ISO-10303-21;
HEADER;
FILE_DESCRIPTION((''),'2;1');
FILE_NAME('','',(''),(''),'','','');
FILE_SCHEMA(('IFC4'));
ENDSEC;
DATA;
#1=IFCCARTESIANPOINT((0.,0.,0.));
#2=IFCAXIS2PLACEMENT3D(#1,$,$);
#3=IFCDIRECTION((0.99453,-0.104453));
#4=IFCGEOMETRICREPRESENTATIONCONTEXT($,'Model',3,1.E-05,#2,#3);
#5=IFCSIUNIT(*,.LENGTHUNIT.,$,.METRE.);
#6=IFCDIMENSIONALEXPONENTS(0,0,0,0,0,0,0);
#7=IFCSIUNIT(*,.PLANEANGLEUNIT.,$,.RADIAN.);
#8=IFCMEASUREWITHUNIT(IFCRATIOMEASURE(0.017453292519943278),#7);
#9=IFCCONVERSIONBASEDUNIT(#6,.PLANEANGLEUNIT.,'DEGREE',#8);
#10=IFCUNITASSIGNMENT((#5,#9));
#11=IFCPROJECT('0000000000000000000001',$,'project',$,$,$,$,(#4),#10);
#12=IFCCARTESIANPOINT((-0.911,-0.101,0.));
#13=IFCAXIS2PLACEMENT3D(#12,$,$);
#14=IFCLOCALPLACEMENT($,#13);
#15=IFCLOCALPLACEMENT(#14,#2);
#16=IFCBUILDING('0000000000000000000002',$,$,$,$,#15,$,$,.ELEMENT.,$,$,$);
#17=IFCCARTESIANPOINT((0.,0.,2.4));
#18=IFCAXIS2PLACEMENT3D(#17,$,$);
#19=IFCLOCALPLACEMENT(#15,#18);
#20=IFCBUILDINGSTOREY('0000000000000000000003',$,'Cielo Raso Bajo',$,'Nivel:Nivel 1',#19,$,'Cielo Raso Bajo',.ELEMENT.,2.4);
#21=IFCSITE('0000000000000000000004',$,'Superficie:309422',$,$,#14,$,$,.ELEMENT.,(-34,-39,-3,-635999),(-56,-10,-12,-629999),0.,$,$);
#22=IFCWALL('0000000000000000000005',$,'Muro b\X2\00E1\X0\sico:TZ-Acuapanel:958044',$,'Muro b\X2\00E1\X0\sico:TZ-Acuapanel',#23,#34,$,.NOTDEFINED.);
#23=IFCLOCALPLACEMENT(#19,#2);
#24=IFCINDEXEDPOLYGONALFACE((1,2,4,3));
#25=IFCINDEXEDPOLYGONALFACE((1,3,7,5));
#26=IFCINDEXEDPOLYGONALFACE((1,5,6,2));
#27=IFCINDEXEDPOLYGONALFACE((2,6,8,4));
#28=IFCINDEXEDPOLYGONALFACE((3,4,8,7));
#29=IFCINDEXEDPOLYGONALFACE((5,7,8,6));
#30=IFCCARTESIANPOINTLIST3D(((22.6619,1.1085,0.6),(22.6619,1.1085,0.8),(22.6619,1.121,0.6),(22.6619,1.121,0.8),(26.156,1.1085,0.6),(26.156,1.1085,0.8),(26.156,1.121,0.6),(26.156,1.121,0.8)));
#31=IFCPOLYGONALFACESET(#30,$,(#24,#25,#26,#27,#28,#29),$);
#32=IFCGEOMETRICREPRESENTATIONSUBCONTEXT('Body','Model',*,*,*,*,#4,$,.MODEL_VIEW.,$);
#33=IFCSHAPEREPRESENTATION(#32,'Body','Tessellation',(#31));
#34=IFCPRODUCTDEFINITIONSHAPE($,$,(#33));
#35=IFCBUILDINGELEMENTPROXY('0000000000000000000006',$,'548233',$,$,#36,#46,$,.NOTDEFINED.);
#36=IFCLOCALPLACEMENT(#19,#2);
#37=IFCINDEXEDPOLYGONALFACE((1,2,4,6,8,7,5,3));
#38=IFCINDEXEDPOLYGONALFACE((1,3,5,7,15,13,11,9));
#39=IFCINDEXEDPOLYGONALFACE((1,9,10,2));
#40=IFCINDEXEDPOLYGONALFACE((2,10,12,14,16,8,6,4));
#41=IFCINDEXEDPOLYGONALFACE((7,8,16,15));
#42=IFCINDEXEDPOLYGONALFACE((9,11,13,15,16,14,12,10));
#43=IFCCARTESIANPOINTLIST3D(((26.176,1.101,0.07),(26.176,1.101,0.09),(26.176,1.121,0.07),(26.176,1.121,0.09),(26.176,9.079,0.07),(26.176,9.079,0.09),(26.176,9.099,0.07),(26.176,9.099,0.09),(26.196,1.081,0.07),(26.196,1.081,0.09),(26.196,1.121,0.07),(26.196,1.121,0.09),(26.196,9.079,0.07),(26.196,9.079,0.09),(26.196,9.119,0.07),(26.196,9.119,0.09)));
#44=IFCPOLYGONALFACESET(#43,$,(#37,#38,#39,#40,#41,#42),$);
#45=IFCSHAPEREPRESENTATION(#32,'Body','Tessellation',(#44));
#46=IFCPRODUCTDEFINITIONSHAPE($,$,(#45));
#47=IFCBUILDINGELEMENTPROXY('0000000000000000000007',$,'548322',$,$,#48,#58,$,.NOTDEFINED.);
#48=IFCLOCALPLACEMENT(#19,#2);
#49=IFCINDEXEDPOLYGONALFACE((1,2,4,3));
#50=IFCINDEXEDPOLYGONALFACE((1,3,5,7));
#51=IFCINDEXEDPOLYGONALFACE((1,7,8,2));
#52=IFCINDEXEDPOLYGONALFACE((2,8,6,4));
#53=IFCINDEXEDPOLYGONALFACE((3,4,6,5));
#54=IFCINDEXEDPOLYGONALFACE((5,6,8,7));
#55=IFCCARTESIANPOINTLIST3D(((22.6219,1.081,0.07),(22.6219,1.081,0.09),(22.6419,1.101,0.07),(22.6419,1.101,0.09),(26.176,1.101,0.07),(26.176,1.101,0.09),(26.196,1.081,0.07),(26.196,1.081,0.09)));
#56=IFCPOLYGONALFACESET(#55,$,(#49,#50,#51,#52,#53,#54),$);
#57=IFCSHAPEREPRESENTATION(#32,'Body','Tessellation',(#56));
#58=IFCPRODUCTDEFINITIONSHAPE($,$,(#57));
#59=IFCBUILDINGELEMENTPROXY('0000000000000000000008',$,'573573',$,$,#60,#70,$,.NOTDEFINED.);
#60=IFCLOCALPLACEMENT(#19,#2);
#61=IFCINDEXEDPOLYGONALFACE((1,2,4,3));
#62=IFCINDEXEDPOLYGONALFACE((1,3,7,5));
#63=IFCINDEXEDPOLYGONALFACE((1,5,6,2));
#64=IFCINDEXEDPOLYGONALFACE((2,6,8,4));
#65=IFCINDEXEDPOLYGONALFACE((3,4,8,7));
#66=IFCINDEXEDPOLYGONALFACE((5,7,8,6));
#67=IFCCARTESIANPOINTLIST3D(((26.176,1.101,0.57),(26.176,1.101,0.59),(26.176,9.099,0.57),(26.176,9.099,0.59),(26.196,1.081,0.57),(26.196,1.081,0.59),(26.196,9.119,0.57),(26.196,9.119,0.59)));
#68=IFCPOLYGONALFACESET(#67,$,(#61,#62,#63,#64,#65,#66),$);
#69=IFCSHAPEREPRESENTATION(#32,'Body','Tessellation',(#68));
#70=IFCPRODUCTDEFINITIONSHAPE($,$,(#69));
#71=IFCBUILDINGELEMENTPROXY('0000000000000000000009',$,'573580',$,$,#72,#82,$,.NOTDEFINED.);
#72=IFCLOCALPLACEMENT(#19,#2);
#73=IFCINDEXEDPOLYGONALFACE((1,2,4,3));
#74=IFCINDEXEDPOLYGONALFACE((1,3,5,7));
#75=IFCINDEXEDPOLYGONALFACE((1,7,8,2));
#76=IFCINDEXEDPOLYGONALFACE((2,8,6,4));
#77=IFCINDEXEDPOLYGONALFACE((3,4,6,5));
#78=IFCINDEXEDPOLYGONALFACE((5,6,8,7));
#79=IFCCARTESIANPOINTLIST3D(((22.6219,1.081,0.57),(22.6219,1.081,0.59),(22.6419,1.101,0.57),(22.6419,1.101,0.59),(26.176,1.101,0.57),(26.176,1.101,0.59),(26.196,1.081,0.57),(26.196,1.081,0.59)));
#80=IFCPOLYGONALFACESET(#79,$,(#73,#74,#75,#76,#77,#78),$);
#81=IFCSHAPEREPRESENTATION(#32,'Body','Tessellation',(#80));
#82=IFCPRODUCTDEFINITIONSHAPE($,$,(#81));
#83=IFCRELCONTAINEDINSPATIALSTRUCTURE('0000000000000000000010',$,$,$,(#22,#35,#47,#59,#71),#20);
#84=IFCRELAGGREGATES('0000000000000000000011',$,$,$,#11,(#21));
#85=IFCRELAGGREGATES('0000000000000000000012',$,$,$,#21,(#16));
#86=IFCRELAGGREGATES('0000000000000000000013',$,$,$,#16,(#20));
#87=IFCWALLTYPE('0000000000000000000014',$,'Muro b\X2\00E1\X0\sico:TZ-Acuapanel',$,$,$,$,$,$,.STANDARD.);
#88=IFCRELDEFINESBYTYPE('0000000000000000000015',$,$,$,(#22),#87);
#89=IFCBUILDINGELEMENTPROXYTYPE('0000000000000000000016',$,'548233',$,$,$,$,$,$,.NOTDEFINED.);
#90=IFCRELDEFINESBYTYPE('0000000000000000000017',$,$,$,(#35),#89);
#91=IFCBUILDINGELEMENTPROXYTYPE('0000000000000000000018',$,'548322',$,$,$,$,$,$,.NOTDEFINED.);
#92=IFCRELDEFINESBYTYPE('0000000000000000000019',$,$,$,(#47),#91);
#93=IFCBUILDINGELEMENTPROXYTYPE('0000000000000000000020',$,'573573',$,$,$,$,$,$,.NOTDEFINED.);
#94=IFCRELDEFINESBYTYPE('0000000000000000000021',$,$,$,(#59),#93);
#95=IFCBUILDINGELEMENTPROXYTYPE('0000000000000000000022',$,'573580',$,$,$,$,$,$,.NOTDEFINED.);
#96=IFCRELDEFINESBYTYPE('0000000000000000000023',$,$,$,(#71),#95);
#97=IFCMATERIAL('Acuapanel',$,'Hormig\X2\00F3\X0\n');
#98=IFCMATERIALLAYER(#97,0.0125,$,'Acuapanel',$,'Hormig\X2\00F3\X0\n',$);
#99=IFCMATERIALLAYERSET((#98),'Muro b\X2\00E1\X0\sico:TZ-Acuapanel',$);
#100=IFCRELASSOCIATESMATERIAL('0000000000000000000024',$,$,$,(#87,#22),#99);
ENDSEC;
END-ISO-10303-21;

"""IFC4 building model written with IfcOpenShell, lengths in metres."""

from ifc_helpers import new_model, entity, si_unit, converted_unit, direction, frame, frame_2d, origin, place, context, subcontext, project, spatial, polyline, rectangle, outline, extrude, clip, bounded_halfspace, material, layer, layer_set, layer_usage, type_object, element, save


model = new_model("IFC4")

# Units and contexts
model_context = context("Model", 3, precision=1e-05, world=origin(), true_north=direction((0.99453, -0.104453)))
body_context = subcontext(model_context, "Body", "Model", "MODEL_VIEW")
ifc_project = project(units=[si_unit("LENGTHUNIT", "METRE"), converted_unit("PLANEANGLEUNIT", "DEGREE", entity("IfcRatioMeasure", 0.017453292519943278), si_unit("PLANEANGLEUNIT", "RADIAN"), dimensions=[0, 0, 0, 0, 0, 0, 0])], contexts=[model_context])

# Site, building, storey
site_placement = place(None, frame((-0.911, -0.101, 0.0)))
site = spatial("IfcSite", under=ifc_project, at=site_placement, Name="Superficie:309422", CompositionType="ELEMENT", RefLatitude=(-34, -39, -3, -635999), RefLongitude=(-56, -10, -12, -629999), RefElevation=0.0)
building_placement = place(site_placement, origin())
building = spatial("IfcBuilding", under=site, at=building_placement, CompositionType="ELEMENT")
storey_placement = place(building_placement, frame((0.0, 0.0, 2.4)))
storey = spatial("IfcBuildingStorey", under=building, at=storey_placement, Name="Cielo Raso Bajo", ObjectType="Nivel:Nivel 1", LongName="Cielo Raso Bajo", CompositionType="ELEMENT", Elevation=2.4)

# Shared definitions
ifc_material_1 = material(Name="Acuapanel", Category="Hormigón")

# Wall
ifc_layer_1 = layer(ifc_material_1, 0.0125, Name="Acuapanel", Category="Hormigón")
ifc_layer_set_1 = layer_set([ifc_layer_1], Name="Muro básico:TZ-Acuapanel")
wall_type_1 = type_object("IfcWallType", Name="Muro básico:TZ-Acuapanel", PredefinedType="STANDARD", material=ifc_layer_set_1)
ifc_layer_usage_1 = layer_usage(ifc_layer_set_1, "AXIS2", "POSITIVE", -0.0063)
wall_1_placement = place(storey_placement, frame((22.6619, 1.1148, 0.6)))
element("IfcWall", 1, at=wall_1_placement, inside=storey, type_object=wall_type_1, material=ifc_layer_usage_1, Name="Muro básico:TZ-Acuapanel:958044", ObjectType="Muro básico:TZ-Acuapanel", PredefinedType="NOTDEFINED", context=body_context, shape_type="Clipping", body=[
    clip(extrude(rectangle(XDim=3.494, YDim=0.0125, at=frame_2d((1.747, 0.0), x_axis=(-1.0, 0.0))), origin(), (0.0, 0.0, 1.0), 0.2), bounded_halfspace(frame((0.0, -0.0062, 0.2)), False, frame((0.0, -0.0062, 0.2)), polyline([(0.0, 0.0), (1.065, 0.0), (1.065, 0.0038), (0.0, 0.0038), (0.0, 0.0)]))),
])

# Building element proxies
building_element_proxy_type_1 = type_object("IfcBuildingElementProxyType", Name="548233", PredefinedType="NOTDEFINED")
proxy_1_placement = place(storey_placement, frame((26.176, 1.081, 0.07)))
element("IfcBuildingElementProxy", 2, at=proxy_1_placement, inside=storey, type_object=building_element_proxy_type_1, Name="548233", PredefinedType="NOTDEFINED", context=body_context, shape_type="SweptSolid", body=[
    extrude(outline(polyline([(-3.999, -0.01), (-3.979, -0.01), (3.979, -0.01), (3.999, -0.01), (4.019, 0.01), (3.979, 0.01), (-3.979, 0.01), (-4.019, 0.01), (-3.999, -0.01)])), frame((0.01, 4.019, 0.0), z_axis=(0.0, 0.0, 1.0), x_axis=(0.0, -1.0, 0.0)), (0.0, 0.0, 1.0), 0.02),
])
building_element_proxy_type_2 = type_object("IfcBuildingElementProxyType", Name="548322", PredefinedType="NOTDEFINED")
proxy_2_placement = place(storey_placement, frame((22.6219, 1.081, 0.07)))
element("IfcBuildingElementProxy", 3, at=proxy_2_placement, inside=storey, type_object=building_element_proxy_type_2, Name="548322", PredefinedType="NOTDEFINED", context=body_context, shape_type="SweptSolid", body=[
    extrude(outline(polyline([(-1.767, -0.01), (1.767, -0.01), (1.787, 0.01), (-1.787, 0.01), (-1.767, -0.01)])), frame((1.787, 0.01, 0.0), z_axis=(0.0, 0.0, 1.0), x_axis=(-1.0, 0.0, 0.0)), (0.0, 0.0, 1.0), 0.02),
])
building_element_proxy_type_3 = type_object("IfcBuildingElementProxyType", Name="573573", PredefinedType="NOTDEFINED")
proxy_3_placement = place(storey_placement, frame((26.176, 1.081, 0.57)))
element("IfcBuildingElementProxy", 4, at=proxy_3_placement, inside=storey, type_object=building_element_proxy_type_3, Name="573573", PredefinedType="NOTDEFINED", context=body_context, shape_type="SweptSolid", body=[
    extrude(outline(polyline([(-3.999, -0.01), (3.999, -0.01), (4.019, 0.01), (-4.019, 0.01), (-3.999, -0.01)])), frame((0.01, 4.019, 0.0), z_axis=(0.0, 0.0, 1.0), x_axis=(0.0, -1.0, 0.0)), (0.0, 0.0, 1.0), 0.02),
])
building_element_proxy_type_4 = type_object("IfcBuildingElementProxyType", Name="573580", PredefinedType="NOTDEFINED")
proxy_4_placement = place(storey_placement, frame((22.6219, 1.081, 0.57)))
element("IfcBuildingElementProxy", 5, at=proxy_4_placement, inside=storey, type_object=building_element_proxy_type_4, Name="573580", PredefinedType="NOTDEFINED", context=body_context, shape_type="SweptSolid", body=[
    extrude(outline(polyline([(-1.767, -0.01), (1.767, -0.01), (1.787, 0.01), (-1.787, 0.01), (-1.767, -0.01)])), frame((1.787, 0.01, 0.0), z_axis=(0.0, 0.0, 1.0), x_axis=(-1.0, 0.0, 0.0)), (0.0, 0.0, 1.0), 0.02),
])

save(model, "model.ifc")
